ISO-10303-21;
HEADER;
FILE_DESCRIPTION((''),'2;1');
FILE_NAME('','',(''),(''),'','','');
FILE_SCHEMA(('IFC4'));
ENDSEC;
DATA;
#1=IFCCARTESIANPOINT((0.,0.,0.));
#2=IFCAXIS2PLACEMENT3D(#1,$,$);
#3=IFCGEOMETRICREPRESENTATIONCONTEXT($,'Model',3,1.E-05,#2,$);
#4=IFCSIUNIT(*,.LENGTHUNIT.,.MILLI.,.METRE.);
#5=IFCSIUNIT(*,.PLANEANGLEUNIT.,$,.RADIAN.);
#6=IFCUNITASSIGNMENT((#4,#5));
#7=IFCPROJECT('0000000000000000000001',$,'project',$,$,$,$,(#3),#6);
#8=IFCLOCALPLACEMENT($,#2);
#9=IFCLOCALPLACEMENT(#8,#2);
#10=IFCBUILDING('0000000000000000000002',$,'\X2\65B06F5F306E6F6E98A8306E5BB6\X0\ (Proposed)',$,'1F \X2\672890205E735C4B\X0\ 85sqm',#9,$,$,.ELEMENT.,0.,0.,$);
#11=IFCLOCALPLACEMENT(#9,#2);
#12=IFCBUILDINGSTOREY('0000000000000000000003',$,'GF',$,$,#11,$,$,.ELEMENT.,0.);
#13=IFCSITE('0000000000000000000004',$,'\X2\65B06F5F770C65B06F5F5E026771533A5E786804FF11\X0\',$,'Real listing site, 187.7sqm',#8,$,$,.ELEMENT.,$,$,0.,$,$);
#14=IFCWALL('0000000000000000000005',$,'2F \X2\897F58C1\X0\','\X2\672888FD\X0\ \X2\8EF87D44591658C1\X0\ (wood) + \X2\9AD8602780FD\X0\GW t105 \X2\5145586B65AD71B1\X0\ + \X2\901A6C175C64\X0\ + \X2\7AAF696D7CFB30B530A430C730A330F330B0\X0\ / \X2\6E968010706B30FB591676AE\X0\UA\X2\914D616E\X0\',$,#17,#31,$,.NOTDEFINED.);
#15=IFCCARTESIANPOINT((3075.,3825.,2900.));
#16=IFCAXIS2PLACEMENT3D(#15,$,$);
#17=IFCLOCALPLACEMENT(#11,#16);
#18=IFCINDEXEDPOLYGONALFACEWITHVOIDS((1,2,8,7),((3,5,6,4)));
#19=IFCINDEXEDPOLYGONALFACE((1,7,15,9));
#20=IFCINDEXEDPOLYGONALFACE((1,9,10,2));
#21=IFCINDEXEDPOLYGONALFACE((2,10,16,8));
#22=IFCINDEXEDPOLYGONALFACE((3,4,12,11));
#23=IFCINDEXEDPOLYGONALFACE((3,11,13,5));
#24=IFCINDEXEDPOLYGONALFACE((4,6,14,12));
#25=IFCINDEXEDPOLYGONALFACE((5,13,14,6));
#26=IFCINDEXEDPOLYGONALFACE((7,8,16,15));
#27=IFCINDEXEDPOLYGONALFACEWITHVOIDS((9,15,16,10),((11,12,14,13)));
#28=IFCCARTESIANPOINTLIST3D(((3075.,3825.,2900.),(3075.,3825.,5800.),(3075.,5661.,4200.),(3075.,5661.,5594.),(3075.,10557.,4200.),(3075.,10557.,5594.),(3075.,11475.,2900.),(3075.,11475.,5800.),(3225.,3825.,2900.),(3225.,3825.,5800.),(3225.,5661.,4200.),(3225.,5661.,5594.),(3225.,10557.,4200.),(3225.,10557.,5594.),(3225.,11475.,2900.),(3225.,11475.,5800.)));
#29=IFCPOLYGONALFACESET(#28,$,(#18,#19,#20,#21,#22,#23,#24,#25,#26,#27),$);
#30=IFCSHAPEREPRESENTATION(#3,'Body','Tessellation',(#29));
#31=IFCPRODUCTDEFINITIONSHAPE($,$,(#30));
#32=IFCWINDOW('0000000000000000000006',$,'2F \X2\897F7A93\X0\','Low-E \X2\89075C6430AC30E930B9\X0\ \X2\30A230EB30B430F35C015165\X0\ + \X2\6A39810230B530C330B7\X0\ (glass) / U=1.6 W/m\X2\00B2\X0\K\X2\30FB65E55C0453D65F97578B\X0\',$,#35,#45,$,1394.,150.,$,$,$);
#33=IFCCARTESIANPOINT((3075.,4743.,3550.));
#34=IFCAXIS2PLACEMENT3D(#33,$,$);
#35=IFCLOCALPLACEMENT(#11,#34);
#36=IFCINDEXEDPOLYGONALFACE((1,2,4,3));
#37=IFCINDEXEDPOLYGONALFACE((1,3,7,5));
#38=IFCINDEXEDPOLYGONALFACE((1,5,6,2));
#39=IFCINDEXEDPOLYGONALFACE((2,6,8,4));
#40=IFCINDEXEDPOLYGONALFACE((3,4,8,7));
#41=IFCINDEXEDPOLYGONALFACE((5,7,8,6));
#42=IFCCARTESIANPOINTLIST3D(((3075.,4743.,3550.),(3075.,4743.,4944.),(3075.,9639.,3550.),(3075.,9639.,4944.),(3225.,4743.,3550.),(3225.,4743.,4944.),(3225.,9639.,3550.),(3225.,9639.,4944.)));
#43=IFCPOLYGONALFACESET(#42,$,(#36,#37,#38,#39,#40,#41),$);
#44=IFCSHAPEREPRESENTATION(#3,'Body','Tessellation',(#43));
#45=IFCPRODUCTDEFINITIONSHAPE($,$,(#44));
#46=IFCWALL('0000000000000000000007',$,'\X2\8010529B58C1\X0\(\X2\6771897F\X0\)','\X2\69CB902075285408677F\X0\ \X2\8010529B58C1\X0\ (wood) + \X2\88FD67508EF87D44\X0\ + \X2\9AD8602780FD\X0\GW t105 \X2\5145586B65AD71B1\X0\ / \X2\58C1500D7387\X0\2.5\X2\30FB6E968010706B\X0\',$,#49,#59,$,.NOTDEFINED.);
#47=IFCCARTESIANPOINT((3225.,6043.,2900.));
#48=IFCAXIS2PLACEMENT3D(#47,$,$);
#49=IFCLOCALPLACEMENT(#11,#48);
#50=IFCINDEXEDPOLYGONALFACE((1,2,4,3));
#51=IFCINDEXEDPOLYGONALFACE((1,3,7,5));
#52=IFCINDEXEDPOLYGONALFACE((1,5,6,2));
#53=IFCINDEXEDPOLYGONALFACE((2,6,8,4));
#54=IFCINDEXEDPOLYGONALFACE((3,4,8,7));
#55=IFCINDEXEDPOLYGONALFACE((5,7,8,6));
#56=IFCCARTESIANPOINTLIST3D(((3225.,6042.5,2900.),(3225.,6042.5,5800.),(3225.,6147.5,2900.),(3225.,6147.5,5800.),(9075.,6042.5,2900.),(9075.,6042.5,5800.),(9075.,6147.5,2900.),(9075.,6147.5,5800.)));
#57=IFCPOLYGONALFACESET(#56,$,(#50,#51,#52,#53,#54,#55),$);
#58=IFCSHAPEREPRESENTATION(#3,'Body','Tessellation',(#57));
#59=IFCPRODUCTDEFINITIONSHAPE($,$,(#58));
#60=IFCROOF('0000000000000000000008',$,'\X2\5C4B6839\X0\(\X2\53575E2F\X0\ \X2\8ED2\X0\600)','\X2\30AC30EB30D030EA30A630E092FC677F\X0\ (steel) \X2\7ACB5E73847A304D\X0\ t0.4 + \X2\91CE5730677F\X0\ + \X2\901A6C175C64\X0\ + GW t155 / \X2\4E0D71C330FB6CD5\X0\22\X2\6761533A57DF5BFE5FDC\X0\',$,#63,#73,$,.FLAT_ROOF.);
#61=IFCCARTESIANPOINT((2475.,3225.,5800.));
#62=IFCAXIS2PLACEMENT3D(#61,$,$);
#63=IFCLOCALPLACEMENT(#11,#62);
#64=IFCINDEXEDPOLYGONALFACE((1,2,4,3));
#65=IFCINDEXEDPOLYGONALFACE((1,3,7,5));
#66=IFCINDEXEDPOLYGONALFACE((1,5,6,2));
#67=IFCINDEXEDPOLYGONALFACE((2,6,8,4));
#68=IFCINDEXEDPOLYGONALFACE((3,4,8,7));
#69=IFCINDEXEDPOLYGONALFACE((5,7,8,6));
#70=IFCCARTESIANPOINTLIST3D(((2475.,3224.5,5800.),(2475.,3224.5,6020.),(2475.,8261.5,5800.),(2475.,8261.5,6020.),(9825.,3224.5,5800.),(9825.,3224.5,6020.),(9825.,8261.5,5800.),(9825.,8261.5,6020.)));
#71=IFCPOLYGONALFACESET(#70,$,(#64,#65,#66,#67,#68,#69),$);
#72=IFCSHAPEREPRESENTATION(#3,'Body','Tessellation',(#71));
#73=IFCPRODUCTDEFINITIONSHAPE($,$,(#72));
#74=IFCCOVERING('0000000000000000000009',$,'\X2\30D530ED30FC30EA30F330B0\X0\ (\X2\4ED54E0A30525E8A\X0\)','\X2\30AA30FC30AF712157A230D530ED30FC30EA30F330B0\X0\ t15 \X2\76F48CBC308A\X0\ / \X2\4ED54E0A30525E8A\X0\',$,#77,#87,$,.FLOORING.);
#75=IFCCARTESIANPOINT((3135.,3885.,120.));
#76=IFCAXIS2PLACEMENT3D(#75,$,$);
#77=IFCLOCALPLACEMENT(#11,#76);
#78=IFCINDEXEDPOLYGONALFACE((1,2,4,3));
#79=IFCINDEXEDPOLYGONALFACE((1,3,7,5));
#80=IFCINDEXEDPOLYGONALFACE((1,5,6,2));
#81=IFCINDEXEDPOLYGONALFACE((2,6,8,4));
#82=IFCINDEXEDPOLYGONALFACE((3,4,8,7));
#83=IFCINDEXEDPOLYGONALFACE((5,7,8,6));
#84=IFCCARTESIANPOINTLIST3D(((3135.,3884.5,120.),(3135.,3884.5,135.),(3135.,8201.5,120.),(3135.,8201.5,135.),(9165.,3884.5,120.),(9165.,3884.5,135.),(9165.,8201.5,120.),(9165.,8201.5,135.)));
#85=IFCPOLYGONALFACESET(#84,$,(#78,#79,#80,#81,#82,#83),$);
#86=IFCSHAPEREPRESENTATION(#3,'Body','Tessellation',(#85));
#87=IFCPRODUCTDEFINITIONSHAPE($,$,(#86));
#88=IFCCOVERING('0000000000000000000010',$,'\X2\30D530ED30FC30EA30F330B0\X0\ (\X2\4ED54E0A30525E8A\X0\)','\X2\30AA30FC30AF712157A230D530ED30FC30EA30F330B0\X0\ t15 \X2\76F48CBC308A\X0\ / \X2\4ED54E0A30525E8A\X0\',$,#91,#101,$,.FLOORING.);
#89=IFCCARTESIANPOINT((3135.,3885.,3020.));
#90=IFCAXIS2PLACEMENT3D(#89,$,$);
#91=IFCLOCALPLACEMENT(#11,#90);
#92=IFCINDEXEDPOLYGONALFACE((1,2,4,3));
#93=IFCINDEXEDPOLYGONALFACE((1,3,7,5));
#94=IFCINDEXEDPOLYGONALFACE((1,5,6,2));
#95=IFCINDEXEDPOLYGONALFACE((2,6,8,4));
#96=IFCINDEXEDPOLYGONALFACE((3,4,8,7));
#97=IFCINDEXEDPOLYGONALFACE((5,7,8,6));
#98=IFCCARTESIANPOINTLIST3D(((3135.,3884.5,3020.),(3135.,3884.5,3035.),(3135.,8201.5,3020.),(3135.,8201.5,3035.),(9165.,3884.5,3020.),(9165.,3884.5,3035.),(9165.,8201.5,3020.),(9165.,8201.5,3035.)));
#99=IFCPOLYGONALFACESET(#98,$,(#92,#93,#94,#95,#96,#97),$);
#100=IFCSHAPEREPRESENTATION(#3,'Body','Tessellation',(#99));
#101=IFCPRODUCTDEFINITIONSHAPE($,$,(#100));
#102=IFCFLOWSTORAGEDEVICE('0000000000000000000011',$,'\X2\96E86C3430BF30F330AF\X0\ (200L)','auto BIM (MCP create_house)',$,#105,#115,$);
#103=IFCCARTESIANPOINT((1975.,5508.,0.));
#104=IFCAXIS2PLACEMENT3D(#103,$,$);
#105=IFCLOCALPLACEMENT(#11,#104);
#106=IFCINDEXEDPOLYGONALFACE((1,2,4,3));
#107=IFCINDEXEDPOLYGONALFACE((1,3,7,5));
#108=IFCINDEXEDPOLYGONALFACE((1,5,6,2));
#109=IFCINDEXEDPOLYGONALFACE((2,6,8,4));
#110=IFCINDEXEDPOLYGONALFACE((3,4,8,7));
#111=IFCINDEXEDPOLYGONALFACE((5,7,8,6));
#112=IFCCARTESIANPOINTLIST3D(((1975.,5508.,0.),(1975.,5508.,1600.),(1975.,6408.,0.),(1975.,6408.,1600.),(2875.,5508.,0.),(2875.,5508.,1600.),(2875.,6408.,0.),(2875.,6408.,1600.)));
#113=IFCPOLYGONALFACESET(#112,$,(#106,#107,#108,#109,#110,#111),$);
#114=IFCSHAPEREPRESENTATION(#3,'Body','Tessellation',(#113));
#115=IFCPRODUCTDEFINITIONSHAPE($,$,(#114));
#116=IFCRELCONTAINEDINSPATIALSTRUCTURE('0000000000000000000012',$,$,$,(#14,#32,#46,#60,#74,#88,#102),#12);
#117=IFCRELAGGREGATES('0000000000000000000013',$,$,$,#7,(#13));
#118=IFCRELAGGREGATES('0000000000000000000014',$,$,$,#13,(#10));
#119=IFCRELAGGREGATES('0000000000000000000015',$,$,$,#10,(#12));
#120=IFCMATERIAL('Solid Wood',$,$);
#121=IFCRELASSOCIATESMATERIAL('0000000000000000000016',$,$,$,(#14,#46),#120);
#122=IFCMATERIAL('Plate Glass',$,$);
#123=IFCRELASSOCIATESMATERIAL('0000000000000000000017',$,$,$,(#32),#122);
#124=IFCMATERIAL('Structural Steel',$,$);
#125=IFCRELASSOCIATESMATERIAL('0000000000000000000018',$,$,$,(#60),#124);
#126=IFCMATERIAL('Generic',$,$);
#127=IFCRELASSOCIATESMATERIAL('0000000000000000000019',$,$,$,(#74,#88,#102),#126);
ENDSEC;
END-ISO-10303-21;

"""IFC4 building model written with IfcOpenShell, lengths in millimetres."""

from ifc_helpers import new_model, si_unit, frame, frame_2d, origin, place, context, project, spatial, rectangle, extrude, material, element, fill, save


model = new_model("IFC4")

# Units and contexts
model_context = context("Model", 3, precision=1e-05, world=origin())
ifc_project = project(units=[si_unit("LENGTHUNIT", "METRE", prefix="MILLI"), si_unit("PLANEANGLEUNIT", "RADIAN")], contexts=[model_context])

# Site, building, storey
site_placement = place(None, origin())
site = spatial("IfcSite", under=ifc_project, at=site_placement, Name="新潟県新潟市東区幸栄１", ObjectType="Real listing site, 187.7sqm", CompositionType="ELEMENT", RefElevation=0.0)
building_placement = place(site_placement, origin())
building = spatial("IfcBuilding", under=site, at=building_placement, Name="新潟の潮風の家 (Proposed)", ObjectType="1F 木造平屋 85sqm", CompositionType="ELEMENT", ElevationOfRefHeight=0.0, ElevationOfTerrain=0.0)
storey_placement = place(building_placement, origin())
storey = spatial("IfcBuildingStorey", under=building, at=storey_placement, Name="GF", CompositionType="ELEMENT", Elevation=0.0)

# Shared definitions
ifc_material_1 = material(Name="Solid Wood")
ifc_material_2 = material(Name="Generic")

# Shared definitions
ifc_material_3 = material(Name="Plate Glass")

# Wall, opening, window
wall_1_placement = place(storey_placement, frame((3075.0, 3825.0, 2900.0)))
wall_1 = element("IfcWall", 1, at=wall_1_placement, inside=storey, material=ifc_material_1, Name="2F 西壁", Description="木製 軸組外壁 (wood) + 高性能GW t105 充填断熱 + 通気層 + 窯業系サイディング / 準耐火・外皮UA配慮", PredefinedType="NOTDEFINED", context=model_context, shape_type="SweptSolid", body=[
    extrude(rectangle(XDim=150.0, YDim=7650.0, at=frame_2d((75.0, 3825.0))), frame((3075.0, 3825.0, 2900.0)), (0.0, 0.0, 1.0), 2900.0),
])
opening_1_placement = place(storey_placement, frame((3075.0, 4743.0, 3550.0)))
opening_1 = element("IfcOpeningElement", 2, at=opening_1_placement, cuts=wall_1, PredefinedType="NOTDEFINED", context=model_context, shape_type="SweptSolid", body=[
    extrude(rectangle(XDim=150.0, YDim=4896.0, at=frame_2d((75.0, 2448.0))), frame((3075.0, 4743.0, 3550.0)), (0.0, 0.0, 1.0), 1394.0),
])
window_1_placement = place(storey_placement, frame((3075.0, 4743.0, 3550.0)))
window_1 = element("IfcWindow", 3, at=window_1_placement, inside=storey, material=ifc_material_3, Name="2F 西窓", Description="Low-E 複層ガラス アルゴン封入 + 樹脂サッシ (glass) / U=1.6 W/m²K・日射取得型", OverallHeight=1394.0, OverallWidth=150.0, context=model_context, shape_type="SweptSolid", body=[
    extrude(rectangle(XDim=150.0, YDim=4896.0, at=frame_2d((75.0, 2448.0))), frame((3075.0, 4743.0, 3550.0)), (0.0, 0.0, 1.0), 1394.0),
])
fill(opening_1, window_1)

# Wall
wall_2_placement = place(storey_placement, frame((3225.0, 6043.0, 2900.0)))
element("IfcWall", 4, at=wall_2_placement, inside=storey, material=ifc_material_1, Name="耐力壁(東西)", Description="構造用合板 耐力壁 (wood) + 製材軸組 + 高性能GW t105 充填断熱 / 壁倍率2.5・準耐火", PredefinedType="NOTDEFINED", context=model_context, shape_type="SweptSolid", body=[
    extrude(rectangle(XDim=5850.0, YDim=105.0, at=frame_2d((2925.0, 52.0))), frame((3225.0, 6043.0, 2900.0)), (0.0, 0.0, 1.0), 2900.0),
])

# Roof
ifc_material_4 = material(Name="Structural Steel")
for number, where, name in (
    (5, (2475.0, 3225.0, 5800.0), "屋根(南帯 軒600)"),
):
    element("IfcRoof", number, at=place(storey_placement, frame(where)), inside=storey, material=ifc_material_4, Name=name, Description="ガルバリウム鋼板 (steel) 立平葺き t0.4 + 野地板 + 通気層 + GW t155 / 不燃・法22条区域対応", PredefinedType="FLAT_ROOF", context=model_context, shape_type="SweptSolid", body=[
        extrude(rectangle(XDim=7350.0, YDim=5037.0, at=frame_2d((3675.0, 2518.0))), frame((2475.0, 3225.0, 5800.0)), (0.0, 0.0, 1.0), 220.0),
    ])

# Coverings
covering_1_placement = place(storey_placement, frame((3135.0, 3885.0, 120.0)))
element("IfcCovering", 6, at=covering_1_placement, inside=storey, material=ifc_material_2, Name="フローリング (仕上げ床)", Description="オーク無垢フローリング t15 直貼り / 仕上げ床", PredefinedType="FLOORING", context=model_context, shape_type="SweptSolid", body=[
    extrude(rectangle(XDim=6030.0, YDim=4317.0, at=frame_2d((3015.0, 2158.0))), frame((3135.0, 3885.0, 120.0)), (0.0, 0.0, 1.0), 15.0),
])
covering_2_placement = place(storey_placement, frame((3135.0, 3885.0, 3020.0)))
element("IfcCovering", 7, at=covering_2_placement, inside=storey, material=ifc_material_2, Name="フローリング (仕上げ床)", Description="オーク無垢フローリング t15 直貼り / 仕上げ床", PredefinedType="FLOORING", context=model_context, shape_type="SweptSolid", body=[
    extrude(rectangle(XDim=6030.0, YDim=4317.0, at=frame_2d((3015.0, 2158.0))), frame((3135.0, 3885.0, 3020.0)), (0.0, 0.0, 1.0), 15.0),
])

# Flow storage device
flow_storage_device_placement = place(storey_placement, frame((1975.0, 5508.0, 0.0)))
element("IfcFlowStorageDevice", 8, at=flow_storage_device_placement, inside=storey, material=ifc_material_2, Name="雨水タンク (200L)", Description="auto BIM (MCP create_house)", context=model_context, shape_type="SweptSolid", body=[
    extrude(rectangle(XDim=900.0, YDim=900.0, at=frame_2d((450.0, 450.0))), frame((1975.0, 5508.0, 0.0)), (0.0, 0.0, 1.0), 1600.0),
])

save(model, "model.ifc")
